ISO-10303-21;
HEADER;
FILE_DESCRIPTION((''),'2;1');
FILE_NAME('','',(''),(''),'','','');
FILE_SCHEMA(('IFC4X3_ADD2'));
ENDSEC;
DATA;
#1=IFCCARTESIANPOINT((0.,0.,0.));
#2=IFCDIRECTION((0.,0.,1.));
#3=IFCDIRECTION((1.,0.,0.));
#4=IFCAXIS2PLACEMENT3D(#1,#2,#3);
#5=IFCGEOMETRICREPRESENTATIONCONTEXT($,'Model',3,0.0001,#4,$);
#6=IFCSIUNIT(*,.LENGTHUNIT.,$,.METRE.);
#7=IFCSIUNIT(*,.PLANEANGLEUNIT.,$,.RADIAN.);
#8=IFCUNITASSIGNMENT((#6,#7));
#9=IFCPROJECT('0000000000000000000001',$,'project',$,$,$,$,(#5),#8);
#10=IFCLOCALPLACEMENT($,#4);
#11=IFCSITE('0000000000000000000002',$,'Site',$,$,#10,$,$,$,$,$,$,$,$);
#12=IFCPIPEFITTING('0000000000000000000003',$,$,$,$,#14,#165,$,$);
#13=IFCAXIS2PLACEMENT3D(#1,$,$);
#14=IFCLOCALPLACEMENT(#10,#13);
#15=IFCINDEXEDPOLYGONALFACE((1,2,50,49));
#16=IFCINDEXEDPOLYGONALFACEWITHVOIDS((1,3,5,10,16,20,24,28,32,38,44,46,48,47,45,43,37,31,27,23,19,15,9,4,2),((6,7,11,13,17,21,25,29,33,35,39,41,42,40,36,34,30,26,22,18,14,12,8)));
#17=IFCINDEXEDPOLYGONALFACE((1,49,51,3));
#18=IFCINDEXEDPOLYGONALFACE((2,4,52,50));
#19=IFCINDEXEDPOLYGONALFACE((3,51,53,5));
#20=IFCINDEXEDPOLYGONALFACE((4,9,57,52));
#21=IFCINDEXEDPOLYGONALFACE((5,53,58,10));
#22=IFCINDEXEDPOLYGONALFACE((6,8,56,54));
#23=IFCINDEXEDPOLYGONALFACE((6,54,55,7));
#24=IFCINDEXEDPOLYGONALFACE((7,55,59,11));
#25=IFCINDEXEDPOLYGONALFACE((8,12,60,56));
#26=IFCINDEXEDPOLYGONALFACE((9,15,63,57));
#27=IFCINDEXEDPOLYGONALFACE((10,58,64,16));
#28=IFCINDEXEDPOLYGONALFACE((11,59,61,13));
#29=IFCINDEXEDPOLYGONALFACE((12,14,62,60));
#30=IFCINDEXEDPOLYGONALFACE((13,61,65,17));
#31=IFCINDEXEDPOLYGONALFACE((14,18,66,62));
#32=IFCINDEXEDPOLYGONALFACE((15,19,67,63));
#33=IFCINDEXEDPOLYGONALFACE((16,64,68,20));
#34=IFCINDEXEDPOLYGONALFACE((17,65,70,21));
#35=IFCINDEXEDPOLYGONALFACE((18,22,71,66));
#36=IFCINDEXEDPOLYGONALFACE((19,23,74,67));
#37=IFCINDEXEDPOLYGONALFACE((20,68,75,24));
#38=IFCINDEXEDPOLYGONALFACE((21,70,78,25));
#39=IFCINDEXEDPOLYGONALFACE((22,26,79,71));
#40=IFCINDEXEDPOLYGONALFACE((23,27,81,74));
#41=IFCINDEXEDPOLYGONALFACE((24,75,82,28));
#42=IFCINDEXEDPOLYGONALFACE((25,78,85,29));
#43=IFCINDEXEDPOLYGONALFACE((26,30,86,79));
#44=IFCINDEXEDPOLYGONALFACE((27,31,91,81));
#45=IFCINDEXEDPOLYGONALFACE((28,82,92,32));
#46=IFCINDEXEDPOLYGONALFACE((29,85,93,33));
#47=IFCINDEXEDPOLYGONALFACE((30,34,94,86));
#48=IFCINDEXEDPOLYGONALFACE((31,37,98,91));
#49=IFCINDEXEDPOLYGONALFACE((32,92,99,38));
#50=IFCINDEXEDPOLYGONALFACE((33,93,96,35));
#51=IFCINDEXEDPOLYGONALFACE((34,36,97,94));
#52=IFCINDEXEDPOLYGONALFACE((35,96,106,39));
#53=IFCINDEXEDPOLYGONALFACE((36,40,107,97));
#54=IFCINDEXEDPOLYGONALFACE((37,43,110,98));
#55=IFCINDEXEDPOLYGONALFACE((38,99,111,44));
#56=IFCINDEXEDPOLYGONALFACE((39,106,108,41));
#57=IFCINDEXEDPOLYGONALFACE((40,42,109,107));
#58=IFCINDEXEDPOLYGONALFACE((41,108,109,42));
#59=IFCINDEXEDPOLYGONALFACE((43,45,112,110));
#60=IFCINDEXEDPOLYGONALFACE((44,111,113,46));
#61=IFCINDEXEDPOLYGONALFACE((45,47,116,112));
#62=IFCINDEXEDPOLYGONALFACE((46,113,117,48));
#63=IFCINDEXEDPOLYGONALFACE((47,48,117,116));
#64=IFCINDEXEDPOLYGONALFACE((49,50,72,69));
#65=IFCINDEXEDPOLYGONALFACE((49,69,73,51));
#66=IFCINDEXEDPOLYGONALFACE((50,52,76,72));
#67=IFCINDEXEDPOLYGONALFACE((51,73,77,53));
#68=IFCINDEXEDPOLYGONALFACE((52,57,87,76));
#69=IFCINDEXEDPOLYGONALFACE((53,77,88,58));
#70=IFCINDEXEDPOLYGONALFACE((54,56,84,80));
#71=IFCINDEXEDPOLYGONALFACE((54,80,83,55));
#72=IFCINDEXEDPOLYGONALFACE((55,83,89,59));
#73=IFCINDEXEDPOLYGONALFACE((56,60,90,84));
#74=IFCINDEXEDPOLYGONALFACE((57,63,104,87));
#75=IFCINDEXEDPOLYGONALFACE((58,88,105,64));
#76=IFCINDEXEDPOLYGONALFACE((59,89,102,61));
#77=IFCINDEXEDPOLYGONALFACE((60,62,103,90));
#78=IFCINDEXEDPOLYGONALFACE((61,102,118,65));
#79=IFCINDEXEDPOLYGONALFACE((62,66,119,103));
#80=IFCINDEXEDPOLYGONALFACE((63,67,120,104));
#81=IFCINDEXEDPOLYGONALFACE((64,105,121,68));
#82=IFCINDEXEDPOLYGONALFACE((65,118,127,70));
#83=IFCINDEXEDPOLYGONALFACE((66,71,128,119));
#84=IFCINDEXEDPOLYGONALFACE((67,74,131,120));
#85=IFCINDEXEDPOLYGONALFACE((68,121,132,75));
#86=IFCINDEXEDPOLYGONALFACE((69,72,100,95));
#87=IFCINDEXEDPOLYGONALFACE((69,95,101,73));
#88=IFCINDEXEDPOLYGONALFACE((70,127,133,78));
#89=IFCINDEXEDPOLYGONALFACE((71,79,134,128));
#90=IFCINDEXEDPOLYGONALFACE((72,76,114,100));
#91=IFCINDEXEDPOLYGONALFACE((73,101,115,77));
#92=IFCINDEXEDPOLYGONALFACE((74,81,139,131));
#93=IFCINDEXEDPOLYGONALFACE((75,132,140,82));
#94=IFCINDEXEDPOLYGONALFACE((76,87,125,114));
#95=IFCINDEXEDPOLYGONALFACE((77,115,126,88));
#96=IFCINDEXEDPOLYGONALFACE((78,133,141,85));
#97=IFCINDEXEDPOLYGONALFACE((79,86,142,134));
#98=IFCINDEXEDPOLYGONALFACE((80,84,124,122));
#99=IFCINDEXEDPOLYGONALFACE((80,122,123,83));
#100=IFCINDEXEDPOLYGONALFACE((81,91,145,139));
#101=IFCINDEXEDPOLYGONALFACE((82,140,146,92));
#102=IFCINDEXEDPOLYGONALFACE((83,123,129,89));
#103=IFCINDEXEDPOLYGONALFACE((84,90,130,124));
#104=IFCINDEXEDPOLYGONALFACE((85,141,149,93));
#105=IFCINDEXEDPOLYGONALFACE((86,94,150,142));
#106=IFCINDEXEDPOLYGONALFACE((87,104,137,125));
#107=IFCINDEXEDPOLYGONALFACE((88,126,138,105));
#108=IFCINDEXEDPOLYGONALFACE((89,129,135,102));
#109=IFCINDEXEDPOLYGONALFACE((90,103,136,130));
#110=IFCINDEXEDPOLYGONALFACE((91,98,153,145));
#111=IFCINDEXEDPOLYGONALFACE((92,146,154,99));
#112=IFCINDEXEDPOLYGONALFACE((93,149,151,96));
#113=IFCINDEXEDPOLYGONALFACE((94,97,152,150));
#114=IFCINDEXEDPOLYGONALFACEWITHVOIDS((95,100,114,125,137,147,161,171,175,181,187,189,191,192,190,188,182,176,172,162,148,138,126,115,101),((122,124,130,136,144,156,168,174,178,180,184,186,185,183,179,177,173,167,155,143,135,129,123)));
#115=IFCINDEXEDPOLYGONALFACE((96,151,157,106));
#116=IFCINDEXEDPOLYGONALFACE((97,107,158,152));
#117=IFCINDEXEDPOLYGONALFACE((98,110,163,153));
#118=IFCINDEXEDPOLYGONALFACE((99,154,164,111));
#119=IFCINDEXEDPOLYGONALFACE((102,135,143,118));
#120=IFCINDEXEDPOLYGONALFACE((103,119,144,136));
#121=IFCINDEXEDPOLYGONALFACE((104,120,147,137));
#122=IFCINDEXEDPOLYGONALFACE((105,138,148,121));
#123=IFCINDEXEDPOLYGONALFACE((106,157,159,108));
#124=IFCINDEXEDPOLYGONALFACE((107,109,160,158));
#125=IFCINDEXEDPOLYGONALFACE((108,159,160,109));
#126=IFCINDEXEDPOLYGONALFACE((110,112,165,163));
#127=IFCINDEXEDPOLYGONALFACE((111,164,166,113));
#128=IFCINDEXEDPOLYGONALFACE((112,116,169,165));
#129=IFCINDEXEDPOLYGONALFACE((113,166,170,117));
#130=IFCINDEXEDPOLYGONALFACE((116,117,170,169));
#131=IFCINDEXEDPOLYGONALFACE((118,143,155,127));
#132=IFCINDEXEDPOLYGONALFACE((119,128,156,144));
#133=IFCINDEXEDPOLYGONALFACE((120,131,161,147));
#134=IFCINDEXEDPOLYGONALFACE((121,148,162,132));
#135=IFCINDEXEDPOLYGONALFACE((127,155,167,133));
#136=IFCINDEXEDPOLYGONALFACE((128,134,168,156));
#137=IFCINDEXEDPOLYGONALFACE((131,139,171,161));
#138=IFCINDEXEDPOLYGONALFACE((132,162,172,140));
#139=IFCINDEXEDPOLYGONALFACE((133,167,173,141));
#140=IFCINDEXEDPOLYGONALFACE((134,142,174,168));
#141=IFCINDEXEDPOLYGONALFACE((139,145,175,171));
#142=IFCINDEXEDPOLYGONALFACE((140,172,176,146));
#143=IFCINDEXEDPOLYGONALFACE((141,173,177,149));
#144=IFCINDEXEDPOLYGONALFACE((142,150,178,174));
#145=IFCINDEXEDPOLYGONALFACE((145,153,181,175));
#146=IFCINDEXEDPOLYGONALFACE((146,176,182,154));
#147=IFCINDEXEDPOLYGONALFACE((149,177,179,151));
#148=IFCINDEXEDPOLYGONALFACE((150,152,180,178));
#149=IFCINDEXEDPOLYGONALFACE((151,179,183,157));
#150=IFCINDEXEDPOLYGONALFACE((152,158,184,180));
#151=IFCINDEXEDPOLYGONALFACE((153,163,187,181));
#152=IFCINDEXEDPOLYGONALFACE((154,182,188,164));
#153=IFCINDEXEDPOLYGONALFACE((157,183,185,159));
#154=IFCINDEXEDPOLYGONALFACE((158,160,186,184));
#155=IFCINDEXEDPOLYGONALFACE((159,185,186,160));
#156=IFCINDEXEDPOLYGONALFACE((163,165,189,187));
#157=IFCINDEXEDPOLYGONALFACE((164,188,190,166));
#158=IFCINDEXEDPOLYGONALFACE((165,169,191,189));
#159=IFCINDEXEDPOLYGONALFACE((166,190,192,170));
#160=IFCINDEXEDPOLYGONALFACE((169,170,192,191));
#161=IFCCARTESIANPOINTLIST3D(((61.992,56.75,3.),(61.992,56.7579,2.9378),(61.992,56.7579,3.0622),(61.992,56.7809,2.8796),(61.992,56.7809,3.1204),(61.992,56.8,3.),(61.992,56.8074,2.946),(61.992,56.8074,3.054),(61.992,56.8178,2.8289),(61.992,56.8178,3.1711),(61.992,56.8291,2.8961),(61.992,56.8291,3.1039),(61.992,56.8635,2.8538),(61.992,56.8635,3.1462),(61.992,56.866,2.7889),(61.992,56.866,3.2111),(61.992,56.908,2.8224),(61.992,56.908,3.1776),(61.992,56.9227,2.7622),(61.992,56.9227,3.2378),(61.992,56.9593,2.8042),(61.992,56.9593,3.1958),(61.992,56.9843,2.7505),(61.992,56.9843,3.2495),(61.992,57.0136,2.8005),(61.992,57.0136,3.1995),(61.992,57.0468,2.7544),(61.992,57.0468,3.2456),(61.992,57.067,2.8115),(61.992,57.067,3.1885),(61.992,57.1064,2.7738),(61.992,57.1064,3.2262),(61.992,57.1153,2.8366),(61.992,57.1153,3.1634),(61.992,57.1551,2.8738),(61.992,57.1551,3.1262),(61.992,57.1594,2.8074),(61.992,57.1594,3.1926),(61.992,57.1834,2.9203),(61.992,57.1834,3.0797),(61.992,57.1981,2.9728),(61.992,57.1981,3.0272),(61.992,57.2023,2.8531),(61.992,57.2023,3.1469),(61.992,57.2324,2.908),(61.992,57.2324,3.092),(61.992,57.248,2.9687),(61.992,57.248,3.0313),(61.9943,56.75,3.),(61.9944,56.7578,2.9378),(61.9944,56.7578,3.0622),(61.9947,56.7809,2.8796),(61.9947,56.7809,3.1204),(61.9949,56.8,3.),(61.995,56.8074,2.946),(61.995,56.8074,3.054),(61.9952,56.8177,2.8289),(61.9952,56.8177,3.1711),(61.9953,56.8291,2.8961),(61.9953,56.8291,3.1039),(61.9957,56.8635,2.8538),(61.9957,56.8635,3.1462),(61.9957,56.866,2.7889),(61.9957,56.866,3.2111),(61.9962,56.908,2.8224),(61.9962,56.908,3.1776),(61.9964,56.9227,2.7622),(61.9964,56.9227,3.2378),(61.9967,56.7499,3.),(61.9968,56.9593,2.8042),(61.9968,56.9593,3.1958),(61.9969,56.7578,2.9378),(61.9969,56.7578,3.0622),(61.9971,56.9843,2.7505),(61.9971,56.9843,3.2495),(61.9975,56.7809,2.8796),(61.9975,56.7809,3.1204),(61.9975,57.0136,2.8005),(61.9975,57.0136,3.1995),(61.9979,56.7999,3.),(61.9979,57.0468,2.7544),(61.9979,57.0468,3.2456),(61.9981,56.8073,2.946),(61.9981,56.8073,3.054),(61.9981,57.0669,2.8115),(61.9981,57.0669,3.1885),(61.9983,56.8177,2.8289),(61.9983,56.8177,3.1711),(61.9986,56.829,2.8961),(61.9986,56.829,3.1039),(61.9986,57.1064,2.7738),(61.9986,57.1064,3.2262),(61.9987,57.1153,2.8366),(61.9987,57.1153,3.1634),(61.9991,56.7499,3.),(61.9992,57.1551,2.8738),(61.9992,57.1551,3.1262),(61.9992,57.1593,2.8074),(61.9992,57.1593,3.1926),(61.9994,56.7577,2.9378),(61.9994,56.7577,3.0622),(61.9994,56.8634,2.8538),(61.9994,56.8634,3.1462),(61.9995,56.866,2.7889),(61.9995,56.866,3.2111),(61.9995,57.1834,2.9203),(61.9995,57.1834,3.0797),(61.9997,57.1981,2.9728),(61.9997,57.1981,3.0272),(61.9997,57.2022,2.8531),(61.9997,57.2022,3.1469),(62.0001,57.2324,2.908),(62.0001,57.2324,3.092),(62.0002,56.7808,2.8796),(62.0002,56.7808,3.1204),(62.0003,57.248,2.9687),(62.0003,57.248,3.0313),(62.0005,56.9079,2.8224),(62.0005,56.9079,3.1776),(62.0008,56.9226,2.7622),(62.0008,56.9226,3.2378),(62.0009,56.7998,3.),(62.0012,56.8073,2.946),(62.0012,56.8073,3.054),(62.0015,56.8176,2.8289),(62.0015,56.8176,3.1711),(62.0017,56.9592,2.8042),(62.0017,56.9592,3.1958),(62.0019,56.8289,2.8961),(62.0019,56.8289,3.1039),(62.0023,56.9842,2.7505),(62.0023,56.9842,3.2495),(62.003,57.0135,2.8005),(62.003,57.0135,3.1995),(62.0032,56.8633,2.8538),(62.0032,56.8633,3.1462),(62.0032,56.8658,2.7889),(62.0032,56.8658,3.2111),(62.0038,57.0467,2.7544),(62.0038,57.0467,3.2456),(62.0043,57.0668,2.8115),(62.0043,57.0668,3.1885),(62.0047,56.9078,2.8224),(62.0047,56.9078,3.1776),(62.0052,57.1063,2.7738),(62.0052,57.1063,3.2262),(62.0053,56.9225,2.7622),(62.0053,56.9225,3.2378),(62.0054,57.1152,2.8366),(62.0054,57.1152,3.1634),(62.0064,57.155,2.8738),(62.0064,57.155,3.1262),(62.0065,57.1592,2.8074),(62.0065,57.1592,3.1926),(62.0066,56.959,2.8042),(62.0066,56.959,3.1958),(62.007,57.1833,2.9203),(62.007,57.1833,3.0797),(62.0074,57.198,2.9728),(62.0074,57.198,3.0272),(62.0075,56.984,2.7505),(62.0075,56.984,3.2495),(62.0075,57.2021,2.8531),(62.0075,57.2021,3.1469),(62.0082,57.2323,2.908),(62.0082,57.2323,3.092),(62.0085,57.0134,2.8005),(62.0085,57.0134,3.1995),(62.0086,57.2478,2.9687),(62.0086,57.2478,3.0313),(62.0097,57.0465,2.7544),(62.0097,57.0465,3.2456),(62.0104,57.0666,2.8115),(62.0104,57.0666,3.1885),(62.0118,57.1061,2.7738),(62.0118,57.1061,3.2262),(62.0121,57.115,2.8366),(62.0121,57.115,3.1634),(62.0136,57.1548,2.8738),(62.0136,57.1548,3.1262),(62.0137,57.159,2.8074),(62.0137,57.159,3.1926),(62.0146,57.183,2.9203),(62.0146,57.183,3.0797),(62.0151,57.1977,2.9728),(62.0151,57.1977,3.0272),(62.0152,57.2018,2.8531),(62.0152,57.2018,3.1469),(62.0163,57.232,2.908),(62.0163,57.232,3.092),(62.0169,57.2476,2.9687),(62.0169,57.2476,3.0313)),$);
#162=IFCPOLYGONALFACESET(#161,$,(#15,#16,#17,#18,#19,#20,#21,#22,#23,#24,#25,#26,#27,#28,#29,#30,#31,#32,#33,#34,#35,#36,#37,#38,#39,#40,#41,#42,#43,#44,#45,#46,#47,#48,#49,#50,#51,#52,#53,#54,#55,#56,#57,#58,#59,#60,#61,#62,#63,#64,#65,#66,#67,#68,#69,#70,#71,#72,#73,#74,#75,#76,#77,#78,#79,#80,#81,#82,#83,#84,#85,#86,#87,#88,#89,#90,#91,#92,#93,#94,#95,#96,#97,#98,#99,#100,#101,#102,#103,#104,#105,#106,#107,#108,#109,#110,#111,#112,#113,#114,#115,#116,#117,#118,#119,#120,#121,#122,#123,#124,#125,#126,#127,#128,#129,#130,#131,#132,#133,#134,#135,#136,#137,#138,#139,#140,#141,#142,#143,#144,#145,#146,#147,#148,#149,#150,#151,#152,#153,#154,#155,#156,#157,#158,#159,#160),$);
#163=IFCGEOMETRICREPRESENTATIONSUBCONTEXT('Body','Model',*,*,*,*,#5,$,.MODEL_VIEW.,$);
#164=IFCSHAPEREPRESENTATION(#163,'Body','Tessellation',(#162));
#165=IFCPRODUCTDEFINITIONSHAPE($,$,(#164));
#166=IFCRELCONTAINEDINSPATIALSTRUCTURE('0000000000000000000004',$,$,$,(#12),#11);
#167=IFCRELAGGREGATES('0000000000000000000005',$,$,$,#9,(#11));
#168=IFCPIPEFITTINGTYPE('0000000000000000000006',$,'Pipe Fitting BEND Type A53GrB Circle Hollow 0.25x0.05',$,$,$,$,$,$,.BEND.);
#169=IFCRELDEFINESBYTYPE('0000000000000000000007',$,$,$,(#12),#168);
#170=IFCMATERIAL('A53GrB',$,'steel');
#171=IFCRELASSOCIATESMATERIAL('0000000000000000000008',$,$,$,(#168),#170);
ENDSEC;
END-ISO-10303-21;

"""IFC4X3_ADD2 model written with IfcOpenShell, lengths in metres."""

from ifc_helpers import new_model, entity, si_unit, frame, origin_with_axes, place, context, subcontext, project, spatial, hollow_circle, material, material_profile, profile_set, type_object, element, save


model = new_model("IFC4X3_ADD2")

# Units and contexts
model_context = context("Model", 3, precision=0.0001, world=origin_with_axes())
body_context = subcontext(model_context, "Body", "Model", "MODEL_VIEW")
ifc_project = project(units=[si_unit("LENGTHUNIT", "METRE"), si_unit("PLANEANGLEUNIT", "RADIAN")], contexts=[model_context])

# Site
site_placement = place(None, origin_with_axes())
site = spatial("IfcSite", under=ifc_project, at=site_placement, Name="Site")

# Shared definitions
ifc_material = material(Name="A53GrB", Category="steel")
ifc_material_profile = material_profile(ifc_material, hollow_circle(Radius=0.25, WallThickness=0.05))
ifc_profile_set = profile_set([ifc_material_profile], Name="A53GrB steel Circle Hollow 0.25x0.05")

# Pipe fitting
pipe_fitting_type = type_object("IfcPipeFittingType", Name="Pipe Fitting BEND Type A53GrB Circle Hollow 0.25x0.05", PredefinedType="BEND", material=ifc_profile_set)
pipe_fitting_1_placement = place(None, frame((62.008, 56.9997, 3.0), z_axis=(-0.999363, 0.035692, 0.0), x_axis=(-0.035692, -0.999363, 0.0)))
element("IfcPipeFitting", 1, at=pipe_fitting_1_placement, inside=site, type_object=pipe_fitting_type, context=body_context, shape_type="SweptSolid", body=[
    entity("IfcRevolvedAreaSolid", entity("IfcCircleHollowProfileDef", "AREA", None, None, 0.25, 0.05), entity("IfcAxis2Placement3D", entity("IfcCartesianPoint", [0.0, 0.0, 0.0]), entity("IfcDirection", [0.0, 0.0, 1.0]), entity("IfcDirection", [1.0, 0.0, 0.0])), entity("IfcAxis1Placement", entity("IfcCartesianPoint", [0.45, 0.0, 0.0]), entity("IfcDirection", [0.0, 1.0, 0.0])), 0.035699),
])

save(model, "model.ifc")
